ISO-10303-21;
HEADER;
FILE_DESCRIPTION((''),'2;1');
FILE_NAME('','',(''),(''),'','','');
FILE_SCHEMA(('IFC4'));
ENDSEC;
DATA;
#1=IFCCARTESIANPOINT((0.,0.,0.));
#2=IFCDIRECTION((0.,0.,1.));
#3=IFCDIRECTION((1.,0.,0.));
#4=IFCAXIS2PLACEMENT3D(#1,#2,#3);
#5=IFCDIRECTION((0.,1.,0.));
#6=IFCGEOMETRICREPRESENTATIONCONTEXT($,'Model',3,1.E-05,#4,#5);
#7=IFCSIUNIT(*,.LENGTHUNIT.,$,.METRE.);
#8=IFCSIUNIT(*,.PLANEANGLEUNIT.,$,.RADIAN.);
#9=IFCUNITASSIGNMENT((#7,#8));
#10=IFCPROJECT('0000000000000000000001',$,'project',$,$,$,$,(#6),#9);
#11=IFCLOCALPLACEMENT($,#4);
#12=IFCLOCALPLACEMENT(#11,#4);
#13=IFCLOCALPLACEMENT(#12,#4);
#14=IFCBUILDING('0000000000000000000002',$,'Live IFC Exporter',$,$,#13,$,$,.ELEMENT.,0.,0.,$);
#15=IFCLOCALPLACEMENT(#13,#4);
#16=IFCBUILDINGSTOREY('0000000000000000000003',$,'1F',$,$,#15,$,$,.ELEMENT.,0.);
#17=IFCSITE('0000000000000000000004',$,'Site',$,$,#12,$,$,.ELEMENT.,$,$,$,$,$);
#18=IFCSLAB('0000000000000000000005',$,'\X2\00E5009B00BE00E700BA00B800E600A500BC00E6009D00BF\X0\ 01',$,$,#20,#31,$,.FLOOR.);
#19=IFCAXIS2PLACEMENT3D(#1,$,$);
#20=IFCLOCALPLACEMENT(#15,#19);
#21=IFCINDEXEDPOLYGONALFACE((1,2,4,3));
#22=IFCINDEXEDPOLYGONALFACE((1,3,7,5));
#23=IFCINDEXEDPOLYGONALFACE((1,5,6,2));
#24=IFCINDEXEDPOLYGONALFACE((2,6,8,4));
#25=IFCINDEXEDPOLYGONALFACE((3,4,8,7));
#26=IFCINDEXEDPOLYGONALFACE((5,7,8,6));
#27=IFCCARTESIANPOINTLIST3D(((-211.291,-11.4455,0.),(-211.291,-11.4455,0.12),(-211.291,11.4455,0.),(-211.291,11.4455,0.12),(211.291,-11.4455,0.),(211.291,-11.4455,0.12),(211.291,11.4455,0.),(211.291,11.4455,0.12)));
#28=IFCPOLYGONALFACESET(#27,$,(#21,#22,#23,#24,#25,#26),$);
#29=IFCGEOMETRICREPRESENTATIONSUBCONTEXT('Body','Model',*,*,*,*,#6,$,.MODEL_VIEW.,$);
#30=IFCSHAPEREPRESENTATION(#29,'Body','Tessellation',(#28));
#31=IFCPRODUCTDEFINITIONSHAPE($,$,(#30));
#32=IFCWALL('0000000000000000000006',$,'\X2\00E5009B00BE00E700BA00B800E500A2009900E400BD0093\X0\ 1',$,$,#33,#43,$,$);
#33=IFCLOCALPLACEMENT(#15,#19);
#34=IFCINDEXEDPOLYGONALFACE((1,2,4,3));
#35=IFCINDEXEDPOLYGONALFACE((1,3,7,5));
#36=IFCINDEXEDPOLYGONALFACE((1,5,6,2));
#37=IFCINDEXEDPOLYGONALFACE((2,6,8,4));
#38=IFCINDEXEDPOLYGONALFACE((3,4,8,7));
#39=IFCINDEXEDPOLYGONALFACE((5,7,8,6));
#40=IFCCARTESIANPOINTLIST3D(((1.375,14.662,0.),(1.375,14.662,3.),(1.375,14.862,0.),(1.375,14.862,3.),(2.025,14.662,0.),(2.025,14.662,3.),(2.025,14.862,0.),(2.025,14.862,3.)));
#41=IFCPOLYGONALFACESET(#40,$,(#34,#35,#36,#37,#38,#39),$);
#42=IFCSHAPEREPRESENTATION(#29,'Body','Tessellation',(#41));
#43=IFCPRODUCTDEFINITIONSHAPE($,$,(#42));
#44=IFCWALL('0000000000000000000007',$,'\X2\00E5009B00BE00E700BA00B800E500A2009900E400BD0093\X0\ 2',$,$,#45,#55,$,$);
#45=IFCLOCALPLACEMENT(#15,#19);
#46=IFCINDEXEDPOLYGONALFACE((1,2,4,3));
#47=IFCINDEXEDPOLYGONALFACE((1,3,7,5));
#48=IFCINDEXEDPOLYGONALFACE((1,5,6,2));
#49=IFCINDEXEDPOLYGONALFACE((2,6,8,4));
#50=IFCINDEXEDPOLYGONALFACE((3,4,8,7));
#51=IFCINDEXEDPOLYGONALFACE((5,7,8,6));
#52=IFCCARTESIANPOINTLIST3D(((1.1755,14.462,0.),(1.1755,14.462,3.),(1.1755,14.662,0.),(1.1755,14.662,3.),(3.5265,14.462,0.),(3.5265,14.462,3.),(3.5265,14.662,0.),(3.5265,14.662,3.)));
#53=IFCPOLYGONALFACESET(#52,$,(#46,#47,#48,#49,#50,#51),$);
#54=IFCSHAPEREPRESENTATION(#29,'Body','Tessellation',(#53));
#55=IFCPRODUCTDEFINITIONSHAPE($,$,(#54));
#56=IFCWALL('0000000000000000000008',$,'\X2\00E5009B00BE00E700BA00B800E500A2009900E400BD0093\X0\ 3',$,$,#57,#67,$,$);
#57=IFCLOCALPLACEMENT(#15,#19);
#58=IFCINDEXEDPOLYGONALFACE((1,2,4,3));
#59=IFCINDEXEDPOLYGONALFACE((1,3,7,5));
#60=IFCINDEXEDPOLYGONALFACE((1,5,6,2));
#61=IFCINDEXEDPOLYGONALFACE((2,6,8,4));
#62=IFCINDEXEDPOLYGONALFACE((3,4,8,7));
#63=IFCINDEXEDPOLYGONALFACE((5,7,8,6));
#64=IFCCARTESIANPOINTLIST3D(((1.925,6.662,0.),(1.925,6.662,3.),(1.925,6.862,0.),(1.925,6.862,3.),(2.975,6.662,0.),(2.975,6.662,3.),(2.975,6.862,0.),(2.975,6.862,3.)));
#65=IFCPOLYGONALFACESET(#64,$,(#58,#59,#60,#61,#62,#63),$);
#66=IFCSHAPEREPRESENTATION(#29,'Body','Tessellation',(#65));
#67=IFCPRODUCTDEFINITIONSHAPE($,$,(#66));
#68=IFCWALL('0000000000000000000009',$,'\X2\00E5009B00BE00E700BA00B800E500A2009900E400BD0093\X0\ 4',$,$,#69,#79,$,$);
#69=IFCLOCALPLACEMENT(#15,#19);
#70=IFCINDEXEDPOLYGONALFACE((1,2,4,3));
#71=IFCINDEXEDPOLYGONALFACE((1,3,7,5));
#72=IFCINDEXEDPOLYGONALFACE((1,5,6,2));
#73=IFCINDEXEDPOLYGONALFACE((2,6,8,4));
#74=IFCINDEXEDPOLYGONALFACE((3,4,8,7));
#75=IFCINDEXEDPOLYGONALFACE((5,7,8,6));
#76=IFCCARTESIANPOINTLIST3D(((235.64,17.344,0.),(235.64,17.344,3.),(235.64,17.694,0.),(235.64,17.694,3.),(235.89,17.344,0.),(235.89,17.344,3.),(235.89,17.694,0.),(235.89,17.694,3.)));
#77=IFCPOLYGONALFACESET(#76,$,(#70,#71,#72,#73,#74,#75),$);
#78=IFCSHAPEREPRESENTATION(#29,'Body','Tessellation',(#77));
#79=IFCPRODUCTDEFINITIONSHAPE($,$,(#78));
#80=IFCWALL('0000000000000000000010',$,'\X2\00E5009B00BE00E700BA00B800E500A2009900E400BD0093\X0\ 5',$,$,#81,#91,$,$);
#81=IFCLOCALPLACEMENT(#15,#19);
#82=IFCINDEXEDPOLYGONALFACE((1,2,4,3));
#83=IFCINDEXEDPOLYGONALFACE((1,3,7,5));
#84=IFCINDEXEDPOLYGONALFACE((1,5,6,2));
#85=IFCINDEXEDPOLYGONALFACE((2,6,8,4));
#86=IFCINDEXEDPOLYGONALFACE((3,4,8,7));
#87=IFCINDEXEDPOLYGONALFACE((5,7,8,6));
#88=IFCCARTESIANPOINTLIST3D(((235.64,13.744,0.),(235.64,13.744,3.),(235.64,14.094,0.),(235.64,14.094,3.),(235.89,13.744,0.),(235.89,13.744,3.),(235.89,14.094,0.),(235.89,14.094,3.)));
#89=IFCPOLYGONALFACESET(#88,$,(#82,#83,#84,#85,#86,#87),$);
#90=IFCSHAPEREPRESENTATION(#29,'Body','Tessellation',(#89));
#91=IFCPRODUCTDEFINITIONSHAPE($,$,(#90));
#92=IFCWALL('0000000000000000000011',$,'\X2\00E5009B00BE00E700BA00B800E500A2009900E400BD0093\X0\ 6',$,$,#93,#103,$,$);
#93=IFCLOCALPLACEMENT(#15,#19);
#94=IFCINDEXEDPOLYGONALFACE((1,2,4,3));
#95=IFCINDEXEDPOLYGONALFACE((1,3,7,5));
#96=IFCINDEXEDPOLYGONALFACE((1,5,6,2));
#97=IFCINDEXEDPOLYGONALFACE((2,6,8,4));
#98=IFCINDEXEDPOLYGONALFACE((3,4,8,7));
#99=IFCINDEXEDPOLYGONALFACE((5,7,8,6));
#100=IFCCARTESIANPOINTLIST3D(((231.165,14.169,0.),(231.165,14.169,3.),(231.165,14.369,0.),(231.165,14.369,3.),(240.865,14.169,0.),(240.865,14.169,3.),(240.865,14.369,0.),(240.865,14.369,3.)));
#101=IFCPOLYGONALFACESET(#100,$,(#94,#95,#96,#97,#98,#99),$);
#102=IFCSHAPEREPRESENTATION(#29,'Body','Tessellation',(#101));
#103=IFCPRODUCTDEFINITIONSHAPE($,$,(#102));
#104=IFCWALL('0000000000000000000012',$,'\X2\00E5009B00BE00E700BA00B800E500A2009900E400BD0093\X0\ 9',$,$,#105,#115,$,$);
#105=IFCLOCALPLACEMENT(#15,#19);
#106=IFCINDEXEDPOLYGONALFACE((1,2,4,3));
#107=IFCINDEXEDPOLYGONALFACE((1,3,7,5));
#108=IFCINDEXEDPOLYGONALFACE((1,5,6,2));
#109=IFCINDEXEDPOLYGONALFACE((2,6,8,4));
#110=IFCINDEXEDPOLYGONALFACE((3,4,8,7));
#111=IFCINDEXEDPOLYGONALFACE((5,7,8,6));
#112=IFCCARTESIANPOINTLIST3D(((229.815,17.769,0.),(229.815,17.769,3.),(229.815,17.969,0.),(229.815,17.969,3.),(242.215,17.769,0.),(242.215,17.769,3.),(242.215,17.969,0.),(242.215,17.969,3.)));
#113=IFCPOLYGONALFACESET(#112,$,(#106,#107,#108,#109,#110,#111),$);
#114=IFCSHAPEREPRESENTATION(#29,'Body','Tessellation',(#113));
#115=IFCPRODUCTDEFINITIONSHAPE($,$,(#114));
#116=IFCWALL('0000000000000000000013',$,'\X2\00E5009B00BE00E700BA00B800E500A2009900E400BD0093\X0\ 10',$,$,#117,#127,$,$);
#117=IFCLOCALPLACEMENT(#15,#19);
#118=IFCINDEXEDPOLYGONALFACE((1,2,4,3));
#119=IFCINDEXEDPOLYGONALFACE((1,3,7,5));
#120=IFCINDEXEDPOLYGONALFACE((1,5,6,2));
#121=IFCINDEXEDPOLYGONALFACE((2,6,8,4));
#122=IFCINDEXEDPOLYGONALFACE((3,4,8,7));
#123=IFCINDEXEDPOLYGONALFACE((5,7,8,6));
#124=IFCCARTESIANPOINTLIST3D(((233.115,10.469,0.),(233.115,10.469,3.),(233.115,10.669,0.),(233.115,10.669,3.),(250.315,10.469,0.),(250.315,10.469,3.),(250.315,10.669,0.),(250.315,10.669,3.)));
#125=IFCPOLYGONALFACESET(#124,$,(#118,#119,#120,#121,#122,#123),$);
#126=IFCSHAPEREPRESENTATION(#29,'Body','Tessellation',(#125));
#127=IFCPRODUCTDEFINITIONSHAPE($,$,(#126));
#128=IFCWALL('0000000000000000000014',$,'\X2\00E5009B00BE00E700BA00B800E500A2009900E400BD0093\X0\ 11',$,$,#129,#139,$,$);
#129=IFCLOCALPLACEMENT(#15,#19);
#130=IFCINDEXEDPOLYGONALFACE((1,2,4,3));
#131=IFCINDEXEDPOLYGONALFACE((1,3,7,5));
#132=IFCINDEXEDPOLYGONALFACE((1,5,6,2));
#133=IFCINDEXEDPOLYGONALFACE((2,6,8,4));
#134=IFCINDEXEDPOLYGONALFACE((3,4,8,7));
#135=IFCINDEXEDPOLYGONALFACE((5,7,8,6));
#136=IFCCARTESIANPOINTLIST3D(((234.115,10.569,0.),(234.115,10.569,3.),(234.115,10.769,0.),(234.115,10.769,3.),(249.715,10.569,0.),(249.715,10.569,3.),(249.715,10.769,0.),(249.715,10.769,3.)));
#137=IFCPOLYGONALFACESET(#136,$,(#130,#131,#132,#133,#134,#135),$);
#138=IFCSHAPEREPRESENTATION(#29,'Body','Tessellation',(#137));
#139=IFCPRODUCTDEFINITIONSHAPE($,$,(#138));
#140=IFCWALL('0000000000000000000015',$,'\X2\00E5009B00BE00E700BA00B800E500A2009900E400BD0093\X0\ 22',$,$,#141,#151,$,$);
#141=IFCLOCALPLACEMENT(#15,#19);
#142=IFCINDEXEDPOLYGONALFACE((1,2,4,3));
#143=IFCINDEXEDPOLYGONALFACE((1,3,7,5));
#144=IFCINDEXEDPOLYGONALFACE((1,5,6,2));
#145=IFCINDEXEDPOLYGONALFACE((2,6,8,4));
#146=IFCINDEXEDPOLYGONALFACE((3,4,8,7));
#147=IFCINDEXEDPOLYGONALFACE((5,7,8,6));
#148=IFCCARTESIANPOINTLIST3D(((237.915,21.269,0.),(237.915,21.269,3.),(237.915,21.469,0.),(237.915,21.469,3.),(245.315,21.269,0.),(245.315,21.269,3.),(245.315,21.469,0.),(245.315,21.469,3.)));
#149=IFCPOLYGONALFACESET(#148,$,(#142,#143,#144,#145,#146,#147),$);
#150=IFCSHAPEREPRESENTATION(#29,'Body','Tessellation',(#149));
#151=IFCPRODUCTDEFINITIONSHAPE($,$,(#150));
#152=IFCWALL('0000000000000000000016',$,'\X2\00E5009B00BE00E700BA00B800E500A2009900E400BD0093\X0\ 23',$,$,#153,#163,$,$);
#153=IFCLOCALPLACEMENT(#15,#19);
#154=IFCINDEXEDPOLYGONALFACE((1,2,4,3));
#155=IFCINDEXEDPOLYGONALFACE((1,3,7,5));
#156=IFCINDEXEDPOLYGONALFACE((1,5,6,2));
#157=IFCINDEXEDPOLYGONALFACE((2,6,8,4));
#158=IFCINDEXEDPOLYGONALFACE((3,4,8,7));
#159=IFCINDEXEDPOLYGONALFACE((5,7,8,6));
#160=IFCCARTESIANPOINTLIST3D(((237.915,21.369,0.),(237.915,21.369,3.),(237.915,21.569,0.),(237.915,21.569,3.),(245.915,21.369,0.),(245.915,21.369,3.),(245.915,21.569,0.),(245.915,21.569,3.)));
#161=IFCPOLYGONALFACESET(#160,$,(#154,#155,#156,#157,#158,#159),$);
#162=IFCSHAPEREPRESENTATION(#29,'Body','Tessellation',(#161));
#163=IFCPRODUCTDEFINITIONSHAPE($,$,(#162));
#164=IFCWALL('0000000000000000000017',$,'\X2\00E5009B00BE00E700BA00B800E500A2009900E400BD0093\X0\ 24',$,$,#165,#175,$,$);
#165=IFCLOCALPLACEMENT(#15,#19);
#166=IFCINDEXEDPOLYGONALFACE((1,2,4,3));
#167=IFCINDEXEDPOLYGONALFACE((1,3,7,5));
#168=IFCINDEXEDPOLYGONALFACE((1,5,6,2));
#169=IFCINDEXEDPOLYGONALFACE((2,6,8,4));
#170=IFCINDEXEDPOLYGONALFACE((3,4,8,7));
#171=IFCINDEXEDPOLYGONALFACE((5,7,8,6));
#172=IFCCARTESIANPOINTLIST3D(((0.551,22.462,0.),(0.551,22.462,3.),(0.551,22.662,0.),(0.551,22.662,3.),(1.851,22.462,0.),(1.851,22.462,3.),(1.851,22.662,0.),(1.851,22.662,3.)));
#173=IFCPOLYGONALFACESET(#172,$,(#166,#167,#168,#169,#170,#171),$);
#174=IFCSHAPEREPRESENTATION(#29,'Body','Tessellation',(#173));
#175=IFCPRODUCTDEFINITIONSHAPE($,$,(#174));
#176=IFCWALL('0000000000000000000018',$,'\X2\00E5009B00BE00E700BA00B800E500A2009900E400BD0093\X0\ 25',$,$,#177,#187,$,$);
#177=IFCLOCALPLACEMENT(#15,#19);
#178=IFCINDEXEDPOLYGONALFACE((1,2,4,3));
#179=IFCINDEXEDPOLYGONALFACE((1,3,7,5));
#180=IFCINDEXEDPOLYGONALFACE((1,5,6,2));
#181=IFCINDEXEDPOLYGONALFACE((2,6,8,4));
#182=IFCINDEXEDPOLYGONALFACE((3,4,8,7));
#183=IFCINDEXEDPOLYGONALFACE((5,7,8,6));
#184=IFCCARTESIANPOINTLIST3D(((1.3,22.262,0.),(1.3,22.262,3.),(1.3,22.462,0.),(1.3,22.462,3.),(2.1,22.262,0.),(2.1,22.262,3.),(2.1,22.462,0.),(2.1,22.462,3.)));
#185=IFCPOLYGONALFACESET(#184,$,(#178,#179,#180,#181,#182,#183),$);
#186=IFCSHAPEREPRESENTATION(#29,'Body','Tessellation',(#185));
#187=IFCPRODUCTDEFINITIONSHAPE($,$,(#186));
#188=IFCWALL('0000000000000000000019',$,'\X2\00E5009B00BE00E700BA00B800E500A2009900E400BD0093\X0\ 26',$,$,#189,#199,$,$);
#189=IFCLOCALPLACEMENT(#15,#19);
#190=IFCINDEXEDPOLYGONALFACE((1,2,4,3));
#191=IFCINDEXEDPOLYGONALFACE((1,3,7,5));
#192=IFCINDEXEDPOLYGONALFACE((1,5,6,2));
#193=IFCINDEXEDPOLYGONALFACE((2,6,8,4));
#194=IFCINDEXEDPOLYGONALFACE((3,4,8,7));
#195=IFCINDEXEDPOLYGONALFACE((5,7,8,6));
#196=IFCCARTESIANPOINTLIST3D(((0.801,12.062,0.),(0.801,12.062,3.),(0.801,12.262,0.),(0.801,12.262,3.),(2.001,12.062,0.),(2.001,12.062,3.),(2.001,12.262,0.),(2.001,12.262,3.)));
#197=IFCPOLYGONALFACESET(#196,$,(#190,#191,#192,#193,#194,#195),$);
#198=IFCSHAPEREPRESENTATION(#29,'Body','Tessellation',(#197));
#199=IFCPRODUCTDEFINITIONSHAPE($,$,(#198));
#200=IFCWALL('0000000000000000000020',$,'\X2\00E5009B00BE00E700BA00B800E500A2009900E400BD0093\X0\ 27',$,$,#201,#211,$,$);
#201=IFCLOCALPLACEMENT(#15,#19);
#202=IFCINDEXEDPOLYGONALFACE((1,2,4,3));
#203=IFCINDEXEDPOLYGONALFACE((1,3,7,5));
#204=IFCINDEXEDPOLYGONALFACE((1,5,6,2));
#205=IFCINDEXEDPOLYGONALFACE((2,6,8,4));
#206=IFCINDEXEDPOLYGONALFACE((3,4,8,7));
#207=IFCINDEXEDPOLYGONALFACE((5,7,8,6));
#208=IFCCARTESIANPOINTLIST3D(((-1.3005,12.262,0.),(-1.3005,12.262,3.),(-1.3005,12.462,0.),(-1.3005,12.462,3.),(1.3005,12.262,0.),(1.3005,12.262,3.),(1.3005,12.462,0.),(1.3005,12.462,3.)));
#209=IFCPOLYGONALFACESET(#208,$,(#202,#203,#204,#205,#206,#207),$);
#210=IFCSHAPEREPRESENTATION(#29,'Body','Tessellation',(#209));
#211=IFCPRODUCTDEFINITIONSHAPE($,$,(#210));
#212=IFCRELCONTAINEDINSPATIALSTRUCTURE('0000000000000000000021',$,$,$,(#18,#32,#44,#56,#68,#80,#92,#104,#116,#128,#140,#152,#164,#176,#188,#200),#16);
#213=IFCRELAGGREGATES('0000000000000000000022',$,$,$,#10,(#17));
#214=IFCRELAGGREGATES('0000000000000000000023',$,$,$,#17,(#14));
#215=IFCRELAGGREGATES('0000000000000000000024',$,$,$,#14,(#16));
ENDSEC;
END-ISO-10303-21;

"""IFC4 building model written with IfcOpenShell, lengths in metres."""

from ifc_helpers import new_model, si_unit, direction, frame, frame_2d, origin_with_axes, place, context, subcontext, project, spatial, rectangle, extrude, element, save


model = new_model("IFC4")

# Units and contexts
model_context = context("Model", 3, precision=1e-05, world=origin_with_axes(), true_north=direction((0.0, 1.0, 0.0)))
body_context = subcontext(model_context, "Body", "Model", "MODEL_VIEW")
ifc_project = project(units=[si_unit("LENGTHUNIT", "METRE"), si_unit("PLANEANGLEUNIT", "RADIAN")], contexts=[model_context])

# Site, building, storey
placement = place(None, origin_with_axes())
site_placement = place(placement, origin_with_axes())
site = spatial("IfcSite", under=ifc_project, at=site_placement, Name="Site", CompositionType="ELEMENT")
building_placement = place(site_placement, origin_with_axes())
building = spatial("IfcBuilding", under=site, at=building_placement, Name="Live IFC Exporter", CompositionType="ELEMENT", ElevationOfRefHeight=0.0, ElevationOfTerrain=0.0)
storey_placement = place(building_placement, origin_with_axes())
storey = spatial("IfcBuildingStorey", under=building, at=storey_placement, Name="1F", CompositionType="ELEMENT", Elevation=0.0)

# Slab
slab_placement = place(storey_placement, origin_with_axes())
element("IfcSlab", 1, at=slab_placement, inside=storey, Name="å\u009b¾çº¸æ¥¼æ\u009d¿ 01", PredefinedType="FLOOR", context=body_context, shape_type="SweptSolid", body=[
    extrude(rectangle(XDim=422.582, YDim=22.891, at=frame_2d((0.0, 0.0), x_axis=(1.0, 0.0, 0.0))), frame((0.0, 0.0, 0.0), z_axis=(0.0, 0.0, 1.0)), (0.0, 0.0, 1.0), 0.12),
])

# Walls
wall_1_placement = place(storey_placement, frame((1.7, 14.762, 0.0), z_axis=(0.0, 0.0, 1.0), x_axis=(1.0, 0.0, 0.0)))
element("IfcWall", 2, at=wall_1_placement, inside=storey, Name="å\u009b¾çº¸å¢\u0099ä½\u0093 1", context=body_context, shape_type="SweptSolid", body=[
    extrude(rectangle(XDim=0.65, YDim=0.2, at=frame_2d((0.0, 0.0), x_axis=(1.0, 0.0, 0.0))), frame((0.0, 0.0, 0.0), z_axis=(0.0, 0.0, 1.0)), (0.0, 0.0, 1.0), 3.0),
])
wall_2_placement = place(storey_placement, frame((2.351, 14.562, 0.0), z_axis=(0.0, 0.0, 1.0), x_axis=(-1.0, 0.0, 0.0)))
element("IfcWall", 3, at=wall_2_placement, inside=storey, Name="å\u009b¾çº¸å¢\u0099ä½\u0093 2", context=body_context, shape_type="SweptSolid", body=[
    extrude(rectangle(XDim=2.351, YDim=0.2, at=frame_2d((0.0, 0.0), x_axis=(1.0, 0.0, 0.0))), frame((0.0, 0.0, 0.0), z_axis=(0.0, 0.0, 1.0)), (0.0, 0.0, 1.0), 3.0),
])
wall_3_placement = place(storey_placement, frame((2.45, 6.762, 0.0), z_axis=(0.0, 0.0, 1.0), x_axis=(-1.0, 0.0, 0.0)))
element("IfcWall", 4, at=wall_3_placement, inside=storey, Name="å\u009b¾çº¸å¢\u0099ä½\u0093 3", context=body_context, shape_type="SweptSolid", body=[
    extrude(rectangle(XDim=1.05, YDim=0.2, at=frame_2d((0.0, 0.0), x_axis=(1.0, 0.0, 0.0))), frame((0.0, 0.0, 0.0), z_axis=(0.0, 0.0, 1.0)), (0.0, 0.0, 1.0), 3.0),
])
for number, where, z_axis, x_axis, name in (
    (5, (235.765, 17.519, 0.0), (0.0, 0.0, 1.0), (1.0, 0.0, 0.0), "å\u009b¾çº¸å¢\u0099ä½\u0093 4"),
    (6, (235.765, 13.919, 0.0), (0.0, 0.0, 1.0), (1.0, 0.0, 0.0), "å\u009b¾çº¸å¢\u0099ä½\u0093 5"),
):
    element("IfcWall", number, at=place(storey_placement, frame(where, z_axis=z_axis, x_axis=x_axis)), inside=storey, Name=name, context=body_context, shape_type="SweptSolid", body=[
        extrude(rectangle(XDim=0.25, YDim=0.35, at=frame_2d((0.0, 0.0), x_axis=(1.0, 0.0, 0.0))), frame((0.0, 0.0, 0.0), z_axis=(0.0, 0.0, 1.0)), (0.0, 0.0, 1.0), 3.0),
    ])
wall_4_placement = place(storey_placement, frame((236.015, 14.269, 0.0), z_axis=(0.0, 0.0, 1.0), x_axis=(-1.0, 0.0, 0.0)))
element("IfcWall", 7, at=wall_4_placement, inside=storey, Name="å\u009b¾çº¸å¢\u0099ä½\u0093 6", context=body_context, shape_type="SweptSolid", body=[
    extrude(rectangle(XDim=9.7, YDim=0.2, at=frame_2d((0.0, 0.0), x_axis=(1.0, 0.0, 0.0))), frame((0.0, 0.0, 0.0), z_axis=(0.0, 0.0, 1.0)), (0.0, 0.0, 1.0), 3.0),
])
wall_5_placement = place(storey_placement, frame((236.015, 17.869, 0.0), z_axis=(0.0, 0.0, 1.0), x_axis=(-1.0, 0.0, 0.0)))
element("IfcWall", 8, at=wall_5_placement, inside=storey, Name="å\u009b¾çº¸å¢\u0099ä½\u0093 9", context=body_context, shape_type="SweptSolid", body=[
    extrude(rectangle(XDim=12.4, YDim=0.2, at=frame_2d((0.0, 0.0), x_axis=(1.0, 0.0, 0.0))), frame((0.0, 0.0, 0.0), z_axis=(0.0, 0.0, 1.0)), (0.0, 0.0, 1.0), 3.0),
])
wall_6_placement = place(storey_placement, frame((241.715, 10.569, 0.0), z_axis=(0.0, 0.0, 1.0), x_axis=(-1.0, 0.0, 0.0)))
element("IfcWall", 9, at=wall_6_placement, inside=storey, Name="å\u009b¾çº¸å¢\u0099ä½\u0093 10", context=body_context, shape_type="SweptSolid", body=[
    extrude(rectangle(XDim=17.2, YDim=0.2, at=frame_2d((0.0, 0.0), x_axis=(1.0, 0.0, 0.0))), frame((0.0, 0.0, 0.0), z_axis=(0.0, 0.0, 1.0)), (0.0, 0.0, 1.0), 3.0),
])
wall_7_placement = place(storey_placement, frame((241.915, 10.669, 0.0), z_axis=(0.0, 0.0, 1.0), x_axis=(-1.0, 0.0, 0.0)))
element("IfcWall", 10, at=wall_7_placement, inside=storey, Name="å\u009b¾çº¸å¢\u0099ä½\u0093 11", context=body_context, shape_type="SweptSolid", body=[
    extrude(rectangle(XDim=15.6, YDim=0.2, at=frame_2d((0.0, 0.0), x_axis=(1.0, 0.0, 0.0))), frame((0.0, 0.0, 0.0), z_axis=(0.0, 0.0, 1.0)), (0.0, 0.0, 1.0), 3.0),
])
wall_8_placement = place(storey_placement, frame((241.615, 21.369, 0.0), z_axis=(0.0, 0.0, 1.0), x_axis=(-1.0, 0.0, 0.0)))
element("IfcWall", 11, at=wall_8_placement, inside=storey, Name="å\u009b¾çº¸å¢\u0099ä½\u0093 22", context=body_context, shape_type="SweptSolid", body=[
    extrude(rectangle(XDim=7.4, YDim=0.2, at=frame_2d((0.0, 0.0), x_axis=(1.0, 0.0, 0.0))), frame((0.0, 0.0, 0.0), z_axis=(0.0, 0.0, 1.0)), (0.0, 0.0, 1.0), 3.0),
])
wall_9_placement = place(storey_placement, frame((241.915, 21.469, 0.0), z_axis=(0.0, 0.0, 1.0), x_axis=(-1.0, 0.0, 0.0)))
element("IfcWall", 12, at=wall_9_placement, inside=storey, Name="å\u009b¾çº¸å¢\u0099ä½\u0093 23", context=body_context, shape_type="SweptSolid", body=[
    extrude(rectangle(XDim=8.0, YDim=0.2, at=frame_2d((0.0, 0.0), x_axis=(1.0, 0.0, 0.0))), frame((0.0, 0.0, 0.0), z_axis=(0.0, 0.0, 1.0)), (0.0, 0.0, 1.0), 3.0),
])
wall_10_placement = place(storey_placement, frame((1.201, 22.562, 0.0), z_axis=(0.0, 0.0, 1.0), x_axis=(1.0, 0.0, 0.0)))
element("IfcWall", 13, at=wall_10_placement, inside=storey, Name="å\u009b¾çº¸å¢\u0099ä½\u0093 24", context=body_context, shape_type="SweptSolid", body=[
    extrude(rectangle(XDim=1.3, YDim=0.2, at=frame_2d((0.0, 0.0), x_axis=(1.0, 0.0, 0.0))), frame((0.0, 0.0, 0.0), z_axis=(0.0, 0.0, 1.0)), (0.0, 0.0, 1.0), 3.0),
])
wall_11_placement = place(storey_placement, frame((1.7, 22.362, 0.0), z_axis=(0.0, 0.0, 1.0), x_axis=(1.0, 0.0, 0.0)))
element("IfcWall", 14, at=wall_11_placement, inside=storey, Name="å\u009b¾çº¸å¢\u0099ä½\u0093 25", context=body_context, shape_type="SweptSolid", body=[
    extrude(rectangle(XDim=0.8, YDim=0.2, at=frame_2d((0.0, 0.0), x_axis=(1.0, 0.0, 0.0))), frame((0.0, 0.0, 0.0), z_axis=(0.0, 0.0, 1.0)), (0.0, 0.0, 1.0), 3.0),
])
wall_12_placement = place(storey_placement, frame((1.401, 12.162, 0.0), z_axis=(0.0, 0.0, 1.0), x_axis=(1.0, 0.0, 0.0)))
element("IfcWall", 15, at=wall_12_placement, inside=storey, Name="å\u009b¾çº¸å¢\u0099ä½\u0093 26", context=body_context, shape_type="SweptSolid", body=[
    extrude(rectangle(XDim=1.2, YDim=0.2, at=frame_2d((0.0, 0.0), x_axis=(1.0, 0.0, 0.0))), frame((0.0, 0.0, 0.0), z_axis=(0.0, 0.0, 1.0)), (0.0, 0.0, 1.0), 3.0),
])
wall_13_placement = place(storey_placement, frame((0.0, 12.362, 0.0), z_axis=(0.0, 0.0, 1.0), x_axis=(1.0, 0.0, 0.0)))
element("IfcWall", 16, at=wall_13_placement, inside=storey, Name="å\u009b¾çº¸å¢\u0099ä½\u0093 27", context=body_context, shape_type="SweptSolid", body=[
    extrude(rectangle(XDim=2.601, YDim=0.2, at=frame_2d((0.0, 0.0), x_axis=(1.0, 0.0, 0.0))), frame((0.0, 0.0, 0.0), z_axis=(0.0, 0.0, 1.0)), (0.0, 0.0, 1.0), 3.0),
])

save(model, "model.ifc")
